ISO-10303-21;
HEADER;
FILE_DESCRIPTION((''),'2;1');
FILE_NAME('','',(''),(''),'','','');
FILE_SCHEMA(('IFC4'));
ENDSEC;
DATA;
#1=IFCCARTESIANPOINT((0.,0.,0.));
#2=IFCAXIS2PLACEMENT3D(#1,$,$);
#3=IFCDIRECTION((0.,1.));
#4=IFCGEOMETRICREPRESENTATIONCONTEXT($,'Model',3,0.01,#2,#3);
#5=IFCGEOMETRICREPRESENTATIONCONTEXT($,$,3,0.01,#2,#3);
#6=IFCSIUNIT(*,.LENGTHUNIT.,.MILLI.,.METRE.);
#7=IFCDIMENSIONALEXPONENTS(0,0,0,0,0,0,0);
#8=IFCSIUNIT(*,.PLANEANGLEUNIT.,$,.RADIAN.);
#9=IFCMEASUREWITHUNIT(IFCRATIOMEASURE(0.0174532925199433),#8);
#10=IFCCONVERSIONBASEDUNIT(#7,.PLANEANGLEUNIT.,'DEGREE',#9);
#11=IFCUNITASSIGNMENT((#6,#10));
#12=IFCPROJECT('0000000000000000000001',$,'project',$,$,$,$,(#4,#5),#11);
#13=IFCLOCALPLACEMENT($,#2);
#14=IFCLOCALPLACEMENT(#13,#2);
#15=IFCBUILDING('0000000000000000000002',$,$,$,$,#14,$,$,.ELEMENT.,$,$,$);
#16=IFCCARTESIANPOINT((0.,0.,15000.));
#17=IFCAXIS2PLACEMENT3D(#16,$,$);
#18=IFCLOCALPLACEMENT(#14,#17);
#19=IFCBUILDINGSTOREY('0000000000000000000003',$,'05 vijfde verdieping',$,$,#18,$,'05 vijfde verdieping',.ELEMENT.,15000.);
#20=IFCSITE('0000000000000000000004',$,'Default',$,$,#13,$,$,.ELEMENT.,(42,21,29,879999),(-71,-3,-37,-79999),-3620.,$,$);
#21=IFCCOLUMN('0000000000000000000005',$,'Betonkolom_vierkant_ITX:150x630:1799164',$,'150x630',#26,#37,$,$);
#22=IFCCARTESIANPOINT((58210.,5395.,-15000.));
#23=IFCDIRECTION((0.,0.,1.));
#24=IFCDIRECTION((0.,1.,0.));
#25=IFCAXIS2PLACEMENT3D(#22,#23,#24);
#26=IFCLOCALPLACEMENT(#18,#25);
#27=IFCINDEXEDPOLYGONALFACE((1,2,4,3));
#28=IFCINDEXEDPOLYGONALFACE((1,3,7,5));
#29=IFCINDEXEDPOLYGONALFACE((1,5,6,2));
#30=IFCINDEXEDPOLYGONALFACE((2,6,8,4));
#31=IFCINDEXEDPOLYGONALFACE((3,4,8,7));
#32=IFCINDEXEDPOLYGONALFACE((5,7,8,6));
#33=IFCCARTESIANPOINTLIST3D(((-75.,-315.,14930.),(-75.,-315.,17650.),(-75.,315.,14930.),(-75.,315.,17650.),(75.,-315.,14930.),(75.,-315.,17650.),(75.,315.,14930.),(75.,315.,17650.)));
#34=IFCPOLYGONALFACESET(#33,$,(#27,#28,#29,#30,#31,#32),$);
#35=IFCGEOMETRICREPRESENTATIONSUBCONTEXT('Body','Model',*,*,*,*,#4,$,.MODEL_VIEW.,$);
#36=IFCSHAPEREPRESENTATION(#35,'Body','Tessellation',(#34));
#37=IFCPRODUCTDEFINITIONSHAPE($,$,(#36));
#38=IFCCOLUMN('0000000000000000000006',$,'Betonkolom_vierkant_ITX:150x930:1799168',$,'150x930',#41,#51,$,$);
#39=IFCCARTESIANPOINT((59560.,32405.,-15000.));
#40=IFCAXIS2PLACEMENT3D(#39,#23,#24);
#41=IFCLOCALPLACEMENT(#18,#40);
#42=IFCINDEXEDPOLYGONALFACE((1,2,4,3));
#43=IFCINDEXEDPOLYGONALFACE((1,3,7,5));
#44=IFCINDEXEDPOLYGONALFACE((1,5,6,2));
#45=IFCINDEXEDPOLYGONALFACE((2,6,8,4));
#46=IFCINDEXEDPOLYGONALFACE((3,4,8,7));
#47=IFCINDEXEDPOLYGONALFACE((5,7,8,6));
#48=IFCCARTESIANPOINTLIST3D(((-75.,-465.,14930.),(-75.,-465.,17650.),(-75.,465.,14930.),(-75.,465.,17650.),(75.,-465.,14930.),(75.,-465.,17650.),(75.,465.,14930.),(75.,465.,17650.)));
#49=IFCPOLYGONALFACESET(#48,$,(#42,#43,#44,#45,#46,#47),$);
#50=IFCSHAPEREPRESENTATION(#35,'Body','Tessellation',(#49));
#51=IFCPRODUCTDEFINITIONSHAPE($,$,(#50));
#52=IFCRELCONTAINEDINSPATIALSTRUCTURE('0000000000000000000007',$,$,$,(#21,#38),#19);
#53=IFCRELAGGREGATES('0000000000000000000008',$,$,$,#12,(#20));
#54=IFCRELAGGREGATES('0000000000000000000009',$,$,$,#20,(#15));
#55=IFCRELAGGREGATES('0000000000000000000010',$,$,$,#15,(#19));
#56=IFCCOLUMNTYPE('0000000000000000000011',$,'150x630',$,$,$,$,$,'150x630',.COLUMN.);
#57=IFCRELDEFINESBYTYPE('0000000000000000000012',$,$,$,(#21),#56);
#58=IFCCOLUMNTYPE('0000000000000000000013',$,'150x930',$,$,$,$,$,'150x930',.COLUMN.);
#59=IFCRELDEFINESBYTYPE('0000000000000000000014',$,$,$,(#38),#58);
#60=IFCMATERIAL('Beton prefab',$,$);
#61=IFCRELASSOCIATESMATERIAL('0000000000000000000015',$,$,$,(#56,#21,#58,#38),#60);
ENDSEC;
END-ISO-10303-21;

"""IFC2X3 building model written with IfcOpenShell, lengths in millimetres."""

from ifc_helpers import new_model, entity, si_unit, converted_unit, direction, frame, origin, origin_2d_with_axis, place, context, subcontext, project, spatial, rectangle, extrude, source, transform, mapped, material, type_object, type_shapes, element, save


model = new_model("IFC2X3")

# Units and contexts
model_context = context("Model", 3, precision=0.01, world=origin(), true_north=direction((0.0, 1.0)))
context_of_model = context(None, 3, precision=0.01, world=origin(), true_north=direction((0.0, 1.0)))
body_context = subcontext(model_context, "Body", "Model", "MODEL_VIEW")
ifc_project = project(units=[si_unit("LENGTHUNIT", "METRE", prefix="MILLI"), converted_unit("PLANEANGLEUNIT", "DEGREE", entity("IfcRatioMeasure", 0.0174532925199433), si_unit("PLANEANGLEUNIT", "RADIAN"), dimensions=[0, 0, 0, 0, 0, 0, 0])], contexts=[model_context, context_of_model])

# Site, building, storey
site_placement = place(None, origin())
site = spatial("IfcSite", under=ifc_project, at=site_placement, Name="Default", CompositionType="ELEMENT", RefLatitude=(42, 21, 29, 879999), RefLongitude=(-71, -3, -37, -79999), RefElevation=-3620.0)
building_placement = place(site_placement, origin())
building = spatial("IfcBuilding", under=site, at=building_placement, CompositionType="ELEMENT")
storey_placement = place(building_placement, frame((0.0, 0.0, 15000.0)))
storey = spatial("IfcBuildingStorey", under=building, at=storey_placement, Name="05 vijfde verdieping", LongName="05 vijfde verdieping", CompositionType="ELEMENT", Elevation=15000.0)

# Columns
ifc_material_1 = material(Name="Beton prefab")
column_type_1 = type_object("IfcColumnType", Name="150x630", ElementType="150x630", PredefinedType="COLUMN", material=ifc_material_1)
shared_shape_1 = source(origin(), body_context, "Body", "SweptSolid", [
    extrude(rectangle(XDim=630.0, YDim=150.0, at=origin_2d_with_axis()), frame((0.0, 0.0, 14930.0), z_axis=(0.0, 0.0, 1.0), x_axis=(0.0, -1.0, 0.0)), (0.0, 0.0, 1.0), 2720.0),
])
type_shapes(column_type_1, [shared_shape_1])
column_1_placement = place(storey_placement, frame((58210.0, 5395.0, -15000.0), z_axis=(0.0, 0.0, 1.0), x_axis=(0.0, 1.0, 0.0)))
element("IfcColumn", 1, at=column_1_placement, inside=storey, type_object=column_type_1, material=ifc_material_1, Name="Betonkolom_vierkant_ITX:150x630:1799164", ObjectType="150x630", context=body_context, shape_type="MappedRepresentation", body=[
    mapped(shared_shape_1, transform((0.0, 0.0, 0.0), scale=1.0)),
])
column_type_2 = type_object("IfcColumnType", Name="150x930", ElementType="150x930", PredefinedType="COLUMN", material=ifc_material_1)
shared_shape_2 = source(origin(), body_context, "Body", "SweptSolid", [
    extrude(rectangle(XDim=930.0, YDim=150.0, at=origin_2d_with_axis()), frame((0.0, 0.0, 14930.0), z_axis=(0.0, 0.0, 1.0), x_axis=(0.0, -1.0, 0.0)), (0.0, 0.0, 1.0), 2720.0),
])
type_shapes(column_type_2, [shared_shape_2])
column_2_placement = place(storey_placement, frame((59560.0, 32405.0, -15000.0), z_axis=(0.0, 0.0, 1.0), x_axis=(0.0, 1.0, 0.0)))
element("IfcColumn", 2, at=column_2_placement, inside=storey, type_object=column_type_2, material=ifc_material_1, Name="Betonkolom_vierkant_ITX:150x930:1799168", ObjectType="150x930", context=body_context, shape_type="MappedRepresentation", body=[
    mapped(shared_shape_2, transform((0.0, 0.0, 0.0), scale=1.0)),
])

save(model, "model.ifc")
